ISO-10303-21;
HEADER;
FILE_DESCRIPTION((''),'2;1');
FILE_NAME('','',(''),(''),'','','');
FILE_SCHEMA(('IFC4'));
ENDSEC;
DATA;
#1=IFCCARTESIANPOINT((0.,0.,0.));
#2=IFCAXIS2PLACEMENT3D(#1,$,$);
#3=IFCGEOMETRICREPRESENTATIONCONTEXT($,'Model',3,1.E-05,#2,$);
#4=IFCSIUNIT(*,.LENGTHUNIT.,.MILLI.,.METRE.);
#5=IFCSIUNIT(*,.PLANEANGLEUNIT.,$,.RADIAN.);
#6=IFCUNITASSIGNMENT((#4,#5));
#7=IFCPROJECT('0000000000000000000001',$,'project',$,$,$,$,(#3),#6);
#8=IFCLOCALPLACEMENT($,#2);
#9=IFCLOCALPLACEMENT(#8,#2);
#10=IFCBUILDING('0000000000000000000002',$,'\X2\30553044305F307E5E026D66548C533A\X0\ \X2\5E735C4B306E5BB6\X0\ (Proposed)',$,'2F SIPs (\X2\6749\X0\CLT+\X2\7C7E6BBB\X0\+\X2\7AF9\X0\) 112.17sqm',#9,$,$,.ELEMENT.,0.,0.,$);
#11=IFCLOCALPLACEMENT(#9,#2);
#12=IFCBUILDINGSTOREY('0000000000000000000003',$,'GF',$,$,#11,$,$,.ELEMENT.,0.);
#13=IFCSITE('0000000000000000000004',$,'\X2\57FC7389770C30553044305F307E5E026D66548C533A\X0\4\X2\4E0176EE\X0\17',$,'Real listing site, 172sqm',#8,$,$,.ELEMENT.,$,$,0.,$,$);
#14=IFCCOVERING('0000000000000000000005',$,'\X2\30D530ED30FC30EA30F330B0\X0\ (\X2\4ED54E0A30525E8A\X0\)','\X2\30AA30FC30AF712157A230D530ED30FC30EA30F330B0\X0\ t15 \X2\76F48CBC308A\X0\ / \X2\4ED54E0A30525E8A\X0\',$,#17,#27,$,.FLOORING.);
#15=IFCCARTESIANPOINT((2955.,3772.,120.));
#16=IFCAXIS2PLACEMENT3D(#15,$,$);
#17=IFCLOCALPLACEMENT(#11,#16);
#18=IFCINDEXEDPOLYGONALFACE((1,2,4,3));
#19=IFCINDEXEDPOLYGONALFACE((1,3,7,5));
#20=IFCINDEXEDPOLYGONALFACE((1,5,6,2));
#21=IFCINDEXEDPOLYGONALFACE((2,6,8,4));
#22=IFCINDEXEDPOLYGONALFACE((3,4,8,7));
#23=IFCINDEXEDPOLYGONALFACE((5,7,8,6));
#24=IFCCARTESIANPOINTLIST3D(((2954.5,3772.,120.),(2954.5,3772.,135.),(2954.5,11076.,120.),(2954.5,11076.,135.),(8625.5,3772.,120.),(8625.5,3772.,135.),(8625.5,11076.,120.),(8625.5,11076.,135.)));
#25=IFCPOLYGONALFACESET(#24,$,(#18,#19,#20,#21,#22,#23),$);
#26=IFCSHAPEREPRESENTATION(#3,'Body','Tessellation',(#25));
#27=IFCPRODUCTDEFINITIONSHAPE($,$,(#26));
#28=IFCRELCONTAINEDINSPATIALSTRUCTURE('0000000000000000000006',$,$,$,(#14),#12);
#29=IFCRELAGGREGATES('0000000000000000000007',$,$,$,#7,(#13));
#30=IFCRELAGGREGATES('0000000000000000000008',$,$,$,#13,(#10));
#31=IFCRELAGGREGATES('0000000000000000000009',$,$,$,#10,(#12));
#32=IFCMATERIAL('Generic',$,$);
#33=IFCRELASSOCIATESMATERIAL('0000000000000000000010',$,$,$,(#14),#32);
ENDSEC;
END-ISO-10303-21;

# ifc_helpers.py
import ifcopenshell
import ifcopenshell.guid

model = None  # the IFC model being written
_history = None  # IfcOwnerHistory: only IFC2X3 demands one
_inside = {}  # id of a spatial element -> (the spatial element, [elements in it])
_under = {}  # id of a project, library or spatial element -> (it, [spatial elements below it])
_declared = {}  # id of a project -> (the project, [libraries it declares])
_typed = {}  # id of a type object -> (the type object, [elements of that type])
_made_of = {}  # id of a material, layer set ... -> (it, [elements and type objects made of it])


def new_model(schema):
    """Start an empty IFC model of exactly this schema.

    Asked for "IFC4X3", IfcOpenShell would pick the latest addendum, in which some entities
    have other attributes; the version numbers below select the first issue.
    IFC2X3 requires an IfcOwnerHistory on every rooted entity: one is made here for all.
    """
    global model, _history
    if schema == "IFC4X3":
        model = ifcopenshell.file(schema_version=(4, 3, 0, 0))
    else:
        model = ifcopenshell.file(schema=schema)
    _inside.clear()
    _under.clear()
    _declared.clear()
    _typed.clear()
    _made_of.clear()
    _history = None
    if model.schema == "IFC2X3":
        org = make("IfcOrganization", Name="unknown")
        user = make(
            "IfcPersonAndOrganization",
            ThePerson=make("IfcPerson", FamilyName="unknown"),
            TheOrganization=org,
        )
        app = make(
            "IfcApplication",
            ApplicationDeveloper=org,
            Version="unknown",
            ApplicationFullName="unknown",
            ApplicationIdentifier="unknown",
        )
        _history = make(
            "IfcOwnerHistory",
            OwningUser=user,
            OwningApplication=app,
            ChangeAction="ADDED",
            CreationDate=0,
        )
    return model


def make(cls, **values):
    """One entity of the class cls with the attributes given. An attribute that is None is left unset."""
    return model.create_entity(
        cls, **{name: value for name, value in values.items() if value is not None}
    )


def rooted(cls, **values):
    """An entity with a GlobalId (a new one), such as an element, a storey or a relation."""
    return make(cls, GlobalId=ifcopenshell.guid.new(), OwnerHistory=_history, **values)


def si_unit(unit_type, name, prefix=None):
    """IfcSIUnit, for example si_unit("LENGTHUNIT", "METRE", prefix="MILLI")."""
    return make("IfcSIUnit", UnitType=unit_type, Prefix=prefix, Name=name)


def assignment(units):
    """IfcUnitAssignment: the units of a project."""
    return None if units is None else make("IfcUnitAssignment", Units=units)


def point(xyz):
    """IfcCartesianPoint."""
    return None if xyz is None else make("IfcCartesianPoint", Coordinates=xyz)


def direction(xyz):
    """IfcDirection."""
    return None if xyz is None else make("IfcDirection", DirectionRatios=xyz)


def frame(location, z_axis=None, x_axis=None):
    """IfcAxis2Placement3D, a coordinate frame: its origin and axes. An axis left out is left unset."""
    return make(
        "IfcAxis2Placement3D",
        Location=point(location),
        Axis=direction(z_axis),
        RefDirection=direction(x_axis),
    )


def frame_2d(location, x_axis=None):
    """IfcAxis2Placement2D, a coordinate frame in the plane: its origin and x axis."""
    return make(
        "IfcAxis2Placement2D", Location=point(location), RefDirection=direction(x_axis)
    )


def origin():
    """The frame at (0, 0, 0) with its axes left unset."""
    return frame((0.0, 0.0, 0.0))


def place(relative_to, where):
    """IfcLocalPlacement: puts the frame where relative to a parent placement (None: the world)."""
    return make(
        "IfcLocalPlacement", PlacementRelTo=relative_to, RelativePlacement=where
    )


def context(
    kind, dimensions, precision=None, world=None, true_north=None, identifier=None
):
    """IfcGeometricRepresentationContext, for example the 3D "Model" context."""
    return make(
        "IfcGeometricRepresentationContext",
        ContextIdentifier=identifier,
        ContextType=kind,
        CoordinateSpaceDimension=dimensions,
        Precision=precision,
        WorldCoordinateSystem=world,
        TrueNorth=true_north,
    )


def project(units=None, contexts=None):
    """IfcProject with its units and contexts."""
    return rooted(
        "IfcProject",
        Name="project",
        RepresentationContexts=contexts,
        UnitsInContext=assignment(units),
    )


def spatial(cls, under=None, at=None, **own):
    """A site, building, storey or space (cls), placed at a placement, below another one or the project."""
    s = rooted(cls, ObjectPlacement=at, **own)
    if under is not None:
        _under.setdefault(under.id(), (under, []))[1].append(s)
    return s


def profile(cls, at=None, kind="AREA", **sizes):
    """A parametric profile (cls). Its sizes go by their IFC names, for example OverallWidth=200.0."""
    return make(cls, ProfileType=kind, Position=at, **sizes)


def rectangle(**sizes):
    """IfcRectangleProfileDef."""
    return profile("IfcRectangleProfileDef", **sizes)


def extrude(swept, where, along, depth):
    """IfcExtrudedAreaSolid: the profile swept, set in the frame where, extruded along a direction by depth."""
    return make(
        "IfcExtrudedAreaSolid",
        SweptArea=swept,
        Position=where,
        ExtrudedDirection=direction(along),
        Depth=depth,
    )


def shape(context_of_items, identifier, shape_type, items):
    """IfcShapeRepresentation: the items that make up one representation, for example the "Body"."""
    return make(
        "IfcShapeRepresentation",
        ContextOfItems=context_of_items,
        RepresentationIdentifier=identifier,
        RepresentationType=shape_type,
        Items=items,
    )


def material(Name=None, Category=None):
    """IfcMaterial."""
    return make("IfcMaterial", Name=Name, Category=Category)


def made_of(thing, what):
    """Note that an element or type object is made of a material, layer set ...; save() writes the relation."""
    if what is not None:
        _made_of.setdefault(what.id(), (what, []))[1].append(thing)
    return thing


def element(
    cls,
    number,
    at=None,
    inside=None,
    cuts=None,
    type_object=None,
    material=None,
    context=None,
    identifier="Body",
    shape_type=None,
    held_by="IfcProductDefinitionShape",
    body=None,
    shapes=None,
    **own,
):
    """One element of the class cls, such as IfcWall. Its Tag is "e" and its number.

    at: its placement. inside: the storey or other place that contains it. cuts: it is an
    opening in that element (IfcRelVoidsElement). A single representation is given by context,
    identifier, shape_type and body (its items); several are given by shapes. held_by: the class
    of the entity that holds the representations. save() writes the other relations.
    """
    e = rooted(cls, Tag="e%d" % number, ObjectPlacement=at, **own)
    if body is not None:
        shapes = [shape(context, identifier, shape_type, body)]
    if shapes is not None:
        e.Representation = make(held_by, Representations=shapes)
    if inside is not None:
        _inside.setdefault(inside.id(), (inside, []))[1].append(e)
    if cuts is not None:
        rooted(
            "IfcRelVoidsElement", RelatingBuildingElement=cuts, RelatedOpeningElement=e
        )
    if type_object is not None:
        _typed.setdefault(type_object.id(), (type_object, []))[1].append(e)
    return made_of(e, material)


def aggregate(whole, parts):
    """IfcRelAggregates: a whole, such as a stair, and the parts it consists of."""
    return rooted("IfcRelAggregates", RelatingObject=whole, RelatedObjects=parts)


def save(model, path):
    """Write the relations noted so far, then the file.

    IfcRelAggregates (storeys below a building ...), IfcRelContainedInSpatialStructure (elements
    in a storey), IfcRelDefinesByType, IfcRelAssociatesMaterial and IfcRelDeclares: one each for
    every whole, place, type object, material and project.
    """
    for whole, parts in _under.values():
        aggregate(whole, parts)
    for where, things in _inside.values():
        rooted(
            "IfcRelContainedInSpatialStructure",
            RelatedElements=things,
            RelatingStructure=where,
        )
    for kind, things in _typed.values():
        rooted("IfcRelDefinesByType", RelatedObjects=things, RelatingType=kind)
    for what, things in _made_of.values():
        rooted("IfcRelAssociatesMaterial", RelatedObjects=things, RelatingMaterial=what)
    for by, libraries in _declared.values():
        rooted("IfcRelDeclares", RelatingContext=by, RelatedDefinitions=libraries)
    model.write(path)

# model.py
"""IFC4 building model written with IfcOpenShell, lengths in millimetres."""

from ifc_helpers import new_model, si_unit, frame, frame_2d, origin, place, context, project, spatial, rectangle, extrude, material, element, save


model = new_model("IFC4")

# Units and contexts
model_context = context("Model", 3, precision=1e-05, world=origin())
ifc_project = project(units=[si_unit("LENGTHUNIT", "METRE", prefix="MILLI"), si_unit("PLANEANGLEUNIT", "RADIAN")], contexts=[model_context])

# Site, building, storey
site_placement = place(None, origin())
site = spatial("IfcSite", under=ifc_project, at=site_placement, Name="埼玉県さいたま市浦和区4丁目17", ObjectType="Real listing site, 172sqm", CompositionType="ELEMENT", RefElevation=0.0)
building_placement = place(site_placement, origin())
building = spatial("IfcBuilding", under=site, at=building_placement, Name="さいたま市浦和区 平屋の家 (Proposed)", ObjectType="2F SIPs (杉CLT+籾殻+竹) 112.17sqm", CompositionType="ELEMENT", ElevationOfRefHeight=0.0, ElevationOfTerrain=0.0)
storey_placement = place(building_placement, origin())
storey = spatial("IfcBuildingStorey", under=building, at=storey_placement, Name="GF", CompositionType="ELEMENT", Elevation=0.0)

# Shared definitions
ifc_material_1 = material(Name="Generic")

# Covering
covering_placement = place(storey_placement, frame((2955.0, 3772.0, 120.0)))
element("IfcCovering", 1, at=covering_placement, inside=storey, material=ifc_material_1, Name="フローリング (仕上げ床)", Description="オーク無垢フローリング t15 直貼り / 仕上げ床", PredefinedType="FLOORING", context=model_context, shape_type="SweptSolid", body=[
    extrude(rectangle(XDim=5671.0, YDim=7304.0, at=frame_2d((2835.0, 3652.0))), frame((2955.0, 3772.0, 120.0)), (0.0, 0.0, 1.0), 15.0),
])

save(model, "model.ifc")
